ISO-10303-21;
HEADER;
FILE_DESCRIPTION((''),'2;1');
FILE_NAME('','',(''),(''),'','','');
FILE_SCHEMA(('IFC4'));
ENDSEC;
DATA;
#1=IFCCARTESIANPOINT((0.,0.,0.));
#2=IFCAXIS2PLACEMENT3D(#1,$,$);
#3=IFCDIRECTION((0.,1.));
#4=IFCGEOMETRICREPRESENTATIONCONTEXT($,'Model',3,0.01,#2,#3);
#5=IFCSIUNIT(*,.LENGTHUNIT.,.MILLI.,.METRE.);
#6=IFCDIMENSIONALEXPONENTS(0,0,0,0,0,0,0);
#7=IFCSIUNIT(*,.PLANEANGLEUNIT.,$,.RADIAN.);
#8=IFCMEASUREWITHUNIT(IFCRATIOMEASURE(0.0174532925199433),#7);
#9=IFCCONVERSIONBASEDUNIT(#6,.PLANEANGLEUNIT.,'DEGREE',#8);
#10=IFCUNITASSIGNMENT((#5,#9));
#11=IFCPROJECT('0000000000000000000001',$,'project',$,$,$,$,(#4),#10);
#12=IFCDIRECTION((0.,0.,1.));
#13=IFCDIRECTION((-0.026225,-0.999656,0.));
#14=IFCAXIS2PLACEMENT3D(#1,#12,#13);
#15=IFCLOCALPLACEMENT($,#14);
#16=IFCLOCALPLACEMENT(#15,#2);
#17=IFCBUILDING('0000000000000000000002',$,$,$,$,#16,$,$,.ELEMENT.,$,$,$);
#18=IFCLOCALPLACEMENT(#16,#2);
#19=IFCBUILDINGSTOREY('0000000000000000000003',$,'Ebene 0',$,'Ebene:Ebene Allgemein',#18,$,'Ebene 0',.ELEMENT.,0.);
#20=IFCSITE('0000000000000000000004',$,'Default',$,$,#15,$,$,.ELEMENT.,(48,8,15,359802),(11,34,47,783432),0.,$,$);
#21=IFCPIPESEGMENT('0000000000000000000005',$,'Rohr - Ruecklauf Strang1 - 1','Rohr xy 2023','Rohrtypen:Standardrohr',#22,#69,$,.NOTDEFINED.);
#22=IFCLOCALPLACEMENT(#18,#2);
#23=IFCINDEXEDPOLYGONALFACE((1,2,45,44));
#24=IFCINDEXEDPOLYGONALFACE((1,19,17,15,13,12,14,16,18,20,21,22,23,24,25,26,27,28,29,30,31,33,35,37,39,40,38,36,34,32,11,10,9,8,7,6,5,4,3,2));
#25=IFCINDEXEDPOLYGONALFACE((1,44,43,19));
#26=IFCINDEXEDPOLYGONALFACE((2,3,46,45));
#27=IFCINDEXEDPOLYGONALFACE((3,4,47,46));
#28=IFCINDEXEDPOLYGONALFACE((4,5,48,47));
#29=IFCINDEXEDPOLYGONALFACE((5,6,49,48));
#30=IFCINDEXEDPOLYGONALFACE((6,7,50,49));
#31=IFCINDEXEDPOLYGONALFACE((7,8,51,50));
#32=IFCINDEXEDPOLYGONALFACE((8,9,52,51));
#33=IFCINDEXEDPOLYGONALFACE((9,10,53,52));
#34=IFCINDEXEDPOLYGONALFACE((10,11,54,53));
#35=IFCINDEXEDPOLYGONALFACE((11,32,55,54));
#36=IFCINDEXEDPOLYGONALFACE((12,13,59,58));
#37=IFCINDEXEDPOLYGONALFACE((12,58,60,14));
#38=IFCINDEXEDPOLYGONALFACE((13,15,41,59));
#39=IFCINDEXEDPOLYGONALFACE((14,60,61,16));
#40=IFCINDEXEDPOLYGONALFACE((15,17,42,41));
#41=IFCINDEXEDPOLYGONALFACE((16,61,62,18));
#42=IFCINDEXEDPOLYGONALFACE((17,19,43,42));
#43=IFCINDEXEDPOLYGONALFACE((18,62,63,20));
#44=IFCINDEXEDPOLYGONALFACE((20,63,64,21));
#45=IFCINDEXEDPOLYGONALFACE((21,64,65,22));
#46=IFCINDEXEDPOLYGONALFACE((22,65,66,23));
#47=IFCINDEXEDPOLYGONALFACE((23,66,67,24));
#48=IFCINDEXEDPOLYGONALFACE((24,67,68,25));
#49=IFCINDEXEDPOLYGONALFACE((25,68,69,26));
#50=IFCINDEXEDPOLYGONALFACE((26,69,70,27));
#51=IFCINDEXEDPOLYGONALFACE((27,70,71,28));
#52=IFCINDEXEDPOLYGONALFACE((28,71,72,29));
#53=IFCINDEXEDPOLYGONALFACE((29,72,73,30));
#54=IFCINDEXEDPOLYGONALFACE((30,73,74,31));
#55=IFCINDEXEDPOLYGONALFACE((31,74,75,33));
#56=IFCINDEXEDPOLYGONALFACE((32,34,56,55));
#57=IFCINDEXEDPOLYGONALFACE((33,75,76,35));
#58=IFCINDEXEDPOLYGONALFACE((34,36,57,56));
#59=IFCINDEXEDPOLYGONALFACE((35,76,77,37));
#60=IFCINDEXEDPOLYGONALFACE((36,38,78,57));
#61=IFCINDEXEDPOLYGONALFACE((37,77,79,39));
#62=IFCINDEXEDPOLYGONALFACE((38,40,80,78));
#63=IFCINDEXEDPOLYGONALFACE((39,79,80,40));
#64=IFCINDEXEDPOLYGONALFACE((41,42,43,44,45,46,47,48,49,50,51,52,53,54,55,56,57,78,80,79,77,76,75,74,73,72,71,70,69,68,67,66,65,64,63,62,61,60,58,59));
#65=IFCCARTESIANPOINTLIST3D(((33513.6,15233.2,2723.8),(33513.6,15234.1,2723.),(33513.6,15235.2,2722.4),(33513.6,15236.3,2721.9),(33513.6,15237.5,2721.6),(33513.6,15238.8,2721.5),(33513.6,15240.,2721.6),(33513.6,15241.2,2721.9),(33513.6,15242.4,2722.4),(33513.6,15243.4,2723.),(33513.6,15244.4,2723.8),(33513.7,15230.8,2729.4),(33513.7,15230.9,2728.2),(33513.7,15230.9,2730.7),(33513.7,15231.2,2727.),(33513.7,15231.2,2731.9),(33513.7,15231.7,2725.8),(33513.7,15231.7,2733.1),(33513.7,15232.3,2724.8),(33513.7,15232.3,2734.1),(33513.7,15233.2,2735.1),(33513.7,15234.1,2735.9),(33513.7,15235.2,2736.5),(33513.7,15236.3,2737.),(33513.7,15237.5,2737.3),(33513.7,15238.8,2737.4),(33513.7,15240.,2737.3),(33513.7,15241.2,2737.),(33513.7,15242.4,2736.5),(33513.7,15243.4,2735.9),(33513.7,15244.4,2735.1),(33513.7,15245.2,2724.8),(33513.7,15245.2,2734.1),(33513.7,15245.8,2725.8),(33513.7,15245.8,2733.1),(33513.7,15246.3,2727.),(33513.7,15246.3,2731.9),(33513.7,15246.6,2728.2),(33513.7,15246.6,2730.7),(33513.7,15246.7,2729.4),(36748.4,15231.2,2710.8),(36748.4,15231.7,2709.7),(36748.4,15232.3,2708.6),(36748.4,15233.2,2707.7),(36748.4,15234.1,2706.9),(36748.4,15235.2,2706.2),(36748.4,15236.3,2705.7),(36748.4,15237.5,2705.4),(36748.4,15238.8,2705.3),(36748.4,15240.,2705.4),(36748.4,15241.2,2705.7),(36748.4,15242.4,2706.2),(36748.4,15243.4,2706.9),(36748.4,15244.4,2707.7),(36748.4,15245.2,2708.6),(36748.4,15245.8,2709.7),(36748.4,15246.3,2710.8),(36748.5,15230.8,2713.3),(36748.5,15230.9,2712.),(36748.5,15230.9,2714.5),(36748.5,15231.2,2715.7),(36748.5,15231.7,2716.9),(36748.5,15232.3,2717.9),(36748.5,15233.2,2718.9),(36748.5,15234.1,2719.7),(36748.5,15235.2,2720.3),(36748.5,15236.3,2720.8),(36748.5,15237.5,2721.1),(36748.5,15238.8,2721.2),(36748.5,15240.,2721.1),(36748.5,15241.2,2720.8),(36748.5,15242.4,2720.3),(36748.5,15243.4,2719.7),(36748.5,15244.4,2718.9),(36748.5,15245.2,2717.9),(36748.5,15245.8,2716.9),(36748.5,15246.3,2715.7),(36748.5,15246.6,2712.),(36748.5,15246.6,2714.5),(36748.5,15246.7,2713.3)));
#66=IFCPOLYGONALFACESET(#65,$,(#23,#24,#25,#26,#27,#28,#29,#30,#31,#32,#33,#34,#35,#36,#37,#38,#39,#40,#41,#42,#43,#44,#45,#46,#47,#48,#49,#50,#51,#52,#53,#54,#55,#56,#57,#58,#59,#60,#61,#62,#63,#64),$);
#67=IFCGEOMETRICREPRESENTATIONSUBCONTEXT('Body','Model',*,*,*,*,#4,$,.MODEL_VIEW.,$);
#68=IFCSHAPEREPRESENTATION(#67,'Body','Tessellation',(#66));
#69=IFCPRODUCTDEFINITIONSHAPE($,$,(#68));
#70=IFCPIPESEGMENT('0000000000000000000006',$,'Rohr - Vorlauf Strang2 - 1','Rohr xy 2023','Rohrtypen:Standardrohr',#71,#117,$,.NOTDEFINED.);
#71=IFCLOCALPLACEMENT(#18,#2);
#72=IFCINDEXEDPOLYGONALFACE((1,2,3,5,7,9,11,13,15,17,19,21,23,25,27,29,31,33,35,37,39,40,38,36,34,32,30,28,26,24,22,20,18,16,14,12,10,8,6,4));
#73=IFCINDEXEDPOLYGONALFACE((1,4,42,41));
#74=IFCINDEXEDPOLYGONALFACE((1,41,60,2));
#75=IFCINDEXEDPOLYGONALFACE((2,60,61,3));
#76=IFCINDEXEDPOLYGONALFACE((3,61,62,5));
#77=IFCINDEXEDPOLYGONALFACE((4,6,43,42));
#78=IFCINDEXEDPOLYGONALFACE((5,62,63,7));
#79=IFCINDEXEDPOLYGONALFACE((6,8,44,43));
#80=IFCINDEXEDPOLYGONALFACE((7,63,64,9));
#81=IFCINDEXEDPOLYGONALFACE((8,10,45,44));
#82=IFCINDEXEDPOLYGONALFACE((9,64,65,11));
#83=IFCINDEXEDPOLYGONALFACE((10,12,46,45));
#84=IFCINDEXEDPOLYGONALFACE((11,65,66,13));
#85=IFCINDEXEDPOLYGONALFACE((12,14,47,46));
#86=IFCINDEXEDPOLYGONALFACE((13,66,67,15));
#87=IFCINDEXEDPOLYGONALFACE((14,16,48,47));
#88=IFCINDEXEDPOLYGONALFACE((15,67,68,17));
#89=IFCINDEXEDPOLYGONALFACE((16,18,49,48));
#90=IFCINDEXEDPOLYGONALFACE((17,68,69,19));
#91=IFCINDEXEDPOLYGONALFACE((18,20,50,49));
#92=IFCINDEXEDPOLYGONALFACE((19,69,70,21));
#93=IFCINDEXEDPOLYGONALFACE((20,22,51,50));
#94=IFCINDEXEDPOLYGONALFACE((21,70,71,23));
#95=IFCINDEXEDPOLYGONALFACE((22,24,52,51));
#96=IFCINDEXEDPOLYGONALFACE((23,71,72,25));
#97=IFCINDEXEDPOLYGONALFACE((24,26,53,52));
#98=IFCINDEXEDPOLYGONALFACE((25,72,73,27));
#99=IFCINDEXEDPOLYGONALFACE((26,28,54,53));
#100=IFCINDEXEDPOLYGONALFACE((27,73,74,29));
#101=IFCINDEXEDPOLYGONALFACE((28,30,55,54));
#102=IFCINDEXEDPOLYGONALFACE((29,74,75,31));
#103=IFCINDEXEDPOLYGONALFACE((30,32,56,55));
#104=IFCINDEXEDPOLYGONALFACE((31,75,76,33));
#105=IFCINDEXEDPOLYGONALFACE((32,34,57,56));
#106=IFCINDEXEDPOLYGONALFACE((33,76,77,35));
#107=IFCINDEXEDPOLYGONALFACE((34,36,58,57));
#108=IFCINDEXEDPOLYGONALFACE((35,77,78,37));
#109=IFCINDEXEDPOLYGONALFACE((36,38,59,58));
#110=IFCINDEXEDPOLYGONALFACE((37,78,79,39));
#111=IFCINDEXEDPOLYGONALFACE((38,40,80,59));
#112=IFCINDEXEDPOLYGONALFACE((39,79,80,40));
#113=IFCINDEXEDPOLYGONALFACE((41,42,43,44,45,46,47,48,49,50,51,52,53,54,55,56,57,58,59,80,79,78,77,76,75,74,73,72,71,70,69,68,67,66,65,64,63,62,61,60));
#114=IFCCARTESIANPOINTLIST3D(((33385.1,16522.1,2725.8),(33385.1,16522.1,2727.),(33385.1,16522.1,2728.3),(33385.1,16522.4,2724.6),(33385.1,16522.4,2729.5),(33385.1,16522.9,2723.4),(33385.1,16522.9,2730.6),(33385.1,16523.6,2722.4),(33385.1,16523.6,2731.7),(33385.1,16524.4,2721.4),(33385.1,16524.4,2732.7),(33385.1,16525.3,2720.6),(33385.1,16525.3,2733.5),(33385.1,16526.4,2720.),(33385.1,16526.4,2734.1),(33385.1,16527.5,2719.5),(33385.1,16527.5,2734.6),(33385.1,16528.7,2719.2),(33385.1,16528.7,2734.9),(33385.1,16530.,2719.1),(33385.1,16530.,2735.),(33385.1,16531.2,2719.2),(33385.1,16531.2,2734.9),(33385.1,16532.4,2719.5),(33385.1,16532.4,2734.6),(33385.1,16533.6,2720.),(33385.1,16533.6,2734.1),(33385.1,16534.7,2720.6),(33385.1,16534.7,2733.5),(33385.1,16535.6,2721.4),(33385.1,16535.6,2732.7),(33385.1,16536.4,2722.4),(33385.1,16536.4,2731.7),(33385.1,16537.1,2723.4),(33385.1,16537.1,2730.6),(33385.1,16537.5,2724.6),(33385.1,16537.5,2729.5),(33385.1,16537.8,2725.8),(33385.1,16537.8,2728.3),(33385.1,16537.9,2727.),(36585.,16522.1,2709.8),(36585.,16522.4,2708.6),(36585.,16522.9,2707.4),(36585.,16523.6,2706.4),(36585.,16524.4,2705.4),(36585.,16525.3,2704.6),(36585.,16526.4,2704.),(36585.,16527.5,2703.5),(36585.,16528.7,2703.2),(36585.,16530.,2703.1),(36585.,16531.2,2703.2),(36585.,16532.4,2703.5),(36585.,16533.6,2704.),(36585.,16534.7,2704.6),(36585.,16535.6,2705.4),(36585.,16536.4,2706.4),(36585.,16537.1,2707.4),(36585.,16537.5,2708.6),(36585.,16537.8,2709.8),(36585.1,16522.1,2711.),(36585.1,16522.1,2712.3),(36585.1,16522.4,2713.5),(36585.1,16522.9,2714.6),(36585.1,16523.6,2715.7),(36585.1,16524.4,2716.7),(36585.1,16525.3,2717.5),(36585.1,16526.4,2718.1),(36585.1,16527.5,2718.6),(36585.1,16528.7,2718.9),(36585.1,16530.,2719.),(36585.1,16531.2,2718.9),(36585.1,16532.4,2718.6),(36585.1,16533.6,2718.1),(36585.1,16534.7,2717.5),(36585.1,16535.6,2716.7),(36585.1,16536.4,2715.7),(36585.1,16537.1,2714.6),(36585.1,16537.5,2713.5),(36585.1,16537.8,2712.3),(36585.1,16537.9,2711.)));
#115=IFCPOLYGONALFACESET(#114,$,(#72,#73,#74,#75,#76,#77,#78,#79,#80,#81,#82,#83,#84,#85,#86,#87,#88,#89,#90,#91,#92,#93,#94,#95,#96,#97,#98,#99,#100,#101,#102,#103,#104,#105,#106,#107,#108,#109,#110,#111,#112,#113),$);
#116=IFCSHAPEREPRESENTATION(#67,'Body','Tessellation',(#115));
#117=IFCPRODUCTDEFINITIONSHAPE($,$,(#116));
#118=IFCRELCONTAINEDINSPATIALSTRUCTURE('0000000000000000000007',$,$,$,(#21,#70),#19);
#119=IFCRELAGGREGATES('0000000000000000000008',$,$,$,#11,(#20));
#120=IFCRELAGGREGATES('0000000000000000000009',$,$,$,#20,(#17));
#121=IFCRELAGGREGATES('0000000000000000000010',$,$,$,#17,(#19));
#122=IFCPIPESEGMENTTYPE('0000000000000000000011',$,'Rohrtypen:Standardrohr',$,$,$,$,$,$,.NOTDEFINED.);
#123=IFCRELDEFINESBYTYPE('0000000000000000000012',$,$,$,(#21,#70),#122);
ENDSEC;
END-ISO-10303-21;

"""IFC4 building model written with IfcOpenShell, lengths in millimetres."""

from ifc_helpers import new_model, entity, si_unit, converted_unit, direction, frame, origin, place, context, subcontext, project, spatial, indexed_curve, outline, extrude, type_object, element, save


model = new_model("IFC4")

# Units and contexts
model_context = context("Model", 3, precision=0.01, world=origin(), true_north=direction((0.0, 1.0)))
body_context = subcontext(model_context, "Body", "Model", "MODEL_VIEW")
ifc_project = project(units=[si_unit("LENGTHUNIT", "METRE", prefix="MILLI"), converted_unit("PLANEANGLEUNIT", "DEGREE", entity("IfcRatioMeasure", 0.0174532925199433), si_unit("PLANEANGLEUNIT", "RADIAN"), dimensions=[0, 0, 0, 0, 0, 0, 0])], contexts=[model_context])

# Site, building, storey
site_placement = place(None, frame((0.0, 0.0, 0.0), z_axis=(0.0, 0.0, 1.0), x_axis=(-0.026225, -0.999656, 0.0)))
site = spatial("IfcSite", under=ifc_project, at=site_placement, Name="Default", CompositionType="ELEMENT", RefLatitude=(48, 8, 15, 359802), RefLongitude=(11, 34, 47, 783432), RefElevation=0.0)
building_placement = place(site_placement, origin())
building = spatial("IfcBuilding", under=site, at=building_placement, CompositionType="ELEMENT")
storey_placement = place(building_placement, origin())
storey = spatial("IfcBuildingStorey", under=building, at=storey_placement, Name="Ebene 0", ObjectType="Ebene:Ebene Allgemein", LongName="Ebene 0", CompositionType="ELEMENT", Elevation=0.0)

# Pipe segments
pipe_segment_type = type_object("IfcPipeSegmentType", Name="Rohrtypen:Standardrohr", PredefinedType="NOTDEFINED")
pipe_segment_1_placement = place(storey_placement, origin())
element("IfcPipeSegment", 1, at=pipe_segment_1_placement, inside=storey, type_object=pipe_segment_type, Name="Rohr - Ruecklauf Strang1 - 1", Description="Rohr xy 2023", ObjectType="Rohrtypen:Standardrohr", PredefinedType="NOTDEFINED", context=body_context, shape_type="SweptSolid", body=[
    extrude(outline(indexed_curve([(7.9, 0.0), (7.8, 1.2), (7.6, 2.5), (7.1, 3.6), (6.4, 4.7), (5.6, 5.6), (4.7, 6.4), (3.6, 7.1), (2.5, 7.6), (1.2, 7.8), (0.0, 7.9), (-1.2, 7.8), (-2.5, 7.6), (-3.6, 7.1), (-4.7, 6.4), (-5.6, 5.6), (-6.4, 4.7), (-7.1, 3.6), (-7.6, 2.5), (-7.8, 1.2), (-7.9, 0.0), (-7.8, -1.2), (-7.6, -2.5), (-7.1, -3.6), (-6.4, -4.7), (-5.6, -5.6), (-4.7, -6.4), (-3.6, -7.1), (-2.5, -7.6), (-1.2, -7.8), (0.0, -7.9), (1.2, -7.8), (2.5, -7.6), (3.6, -7.1), (4.7, -6.4), (5.6, -5.6), (6.4, -4.7), (7.1, -3.6), (7.6, -2.5), (7.8, -1.2), (7.9, 0.0)], self_intersect=False)), frame((36748.5, 15238.8, 2713.3), z_axis=(-0.999988, 0.0, 0.005), x_axis=(0.0, 1.0, 0.0)), (0.0, 0.0, 1.0), 3234.8),
])
pipe_segment_2_placement = place(storey_placement, origin())
element("IfcPipeSegment", 2, at=pipe_segment_2_placement, inside=storey, type_object=pipe_segment_type, Name="Rohr - Vorlauf Strang2 - 1", Description="Rohr xy 2023", ObjectType="Rohrtypen:Standardrohr", PredefinedType="NOTDEFINED", context=body_context, shape_type="SweptSolid", body=[
    extrude(outline(indexed_curve([(7.9, 0.0), (7.8, 1.2), (7.6, 2.5), (7.1, 3.6), (6.4, 4.7), (5.6, 5.6), (4.7, 6.4), (3.6, 7.1), (2.5, 7.6), (1.2, 7.8), (0.0, 7.9), (-1.2, 7.8), (-2.5, 7.6), (-3.6, 7.1), (-4.7, 6.4), (-5.6, 5.6), (-6.4, 4.7), (-7.1, 3.6), (-7.6, 2.5), (-7.8, 1.2), (-7.9, 0.0), (-7.8, -1.2), (-7.6, -2.5), (-7.1, -3.6), (-6.4, -4.7), (-5.6, -5.6), (-4.7, -6.4), (-3.6, -7.1), (-2.5, -7.6), (-1.2, -7.8), (0.0, -7.9), (1.2, -7.8), (2.5, -7.6), (3.6, -7.1), (4.7, -6.4), (5.6, -5.6), (6.4, -4.7), (7.1, -3.6), (7.6, -2.5), (7.8, -1.2), (7.9, 0.0)], self_intersect=False)), frame((36585.1, 16530.0, 2711.0), z_axis=(-0.999988, 0.0, 0.005), x_axis=(0.0, 1.0, 0.0)), (0.0, 0.0, 1.0), 3200.0),
])

save(model, "model.ifc")
